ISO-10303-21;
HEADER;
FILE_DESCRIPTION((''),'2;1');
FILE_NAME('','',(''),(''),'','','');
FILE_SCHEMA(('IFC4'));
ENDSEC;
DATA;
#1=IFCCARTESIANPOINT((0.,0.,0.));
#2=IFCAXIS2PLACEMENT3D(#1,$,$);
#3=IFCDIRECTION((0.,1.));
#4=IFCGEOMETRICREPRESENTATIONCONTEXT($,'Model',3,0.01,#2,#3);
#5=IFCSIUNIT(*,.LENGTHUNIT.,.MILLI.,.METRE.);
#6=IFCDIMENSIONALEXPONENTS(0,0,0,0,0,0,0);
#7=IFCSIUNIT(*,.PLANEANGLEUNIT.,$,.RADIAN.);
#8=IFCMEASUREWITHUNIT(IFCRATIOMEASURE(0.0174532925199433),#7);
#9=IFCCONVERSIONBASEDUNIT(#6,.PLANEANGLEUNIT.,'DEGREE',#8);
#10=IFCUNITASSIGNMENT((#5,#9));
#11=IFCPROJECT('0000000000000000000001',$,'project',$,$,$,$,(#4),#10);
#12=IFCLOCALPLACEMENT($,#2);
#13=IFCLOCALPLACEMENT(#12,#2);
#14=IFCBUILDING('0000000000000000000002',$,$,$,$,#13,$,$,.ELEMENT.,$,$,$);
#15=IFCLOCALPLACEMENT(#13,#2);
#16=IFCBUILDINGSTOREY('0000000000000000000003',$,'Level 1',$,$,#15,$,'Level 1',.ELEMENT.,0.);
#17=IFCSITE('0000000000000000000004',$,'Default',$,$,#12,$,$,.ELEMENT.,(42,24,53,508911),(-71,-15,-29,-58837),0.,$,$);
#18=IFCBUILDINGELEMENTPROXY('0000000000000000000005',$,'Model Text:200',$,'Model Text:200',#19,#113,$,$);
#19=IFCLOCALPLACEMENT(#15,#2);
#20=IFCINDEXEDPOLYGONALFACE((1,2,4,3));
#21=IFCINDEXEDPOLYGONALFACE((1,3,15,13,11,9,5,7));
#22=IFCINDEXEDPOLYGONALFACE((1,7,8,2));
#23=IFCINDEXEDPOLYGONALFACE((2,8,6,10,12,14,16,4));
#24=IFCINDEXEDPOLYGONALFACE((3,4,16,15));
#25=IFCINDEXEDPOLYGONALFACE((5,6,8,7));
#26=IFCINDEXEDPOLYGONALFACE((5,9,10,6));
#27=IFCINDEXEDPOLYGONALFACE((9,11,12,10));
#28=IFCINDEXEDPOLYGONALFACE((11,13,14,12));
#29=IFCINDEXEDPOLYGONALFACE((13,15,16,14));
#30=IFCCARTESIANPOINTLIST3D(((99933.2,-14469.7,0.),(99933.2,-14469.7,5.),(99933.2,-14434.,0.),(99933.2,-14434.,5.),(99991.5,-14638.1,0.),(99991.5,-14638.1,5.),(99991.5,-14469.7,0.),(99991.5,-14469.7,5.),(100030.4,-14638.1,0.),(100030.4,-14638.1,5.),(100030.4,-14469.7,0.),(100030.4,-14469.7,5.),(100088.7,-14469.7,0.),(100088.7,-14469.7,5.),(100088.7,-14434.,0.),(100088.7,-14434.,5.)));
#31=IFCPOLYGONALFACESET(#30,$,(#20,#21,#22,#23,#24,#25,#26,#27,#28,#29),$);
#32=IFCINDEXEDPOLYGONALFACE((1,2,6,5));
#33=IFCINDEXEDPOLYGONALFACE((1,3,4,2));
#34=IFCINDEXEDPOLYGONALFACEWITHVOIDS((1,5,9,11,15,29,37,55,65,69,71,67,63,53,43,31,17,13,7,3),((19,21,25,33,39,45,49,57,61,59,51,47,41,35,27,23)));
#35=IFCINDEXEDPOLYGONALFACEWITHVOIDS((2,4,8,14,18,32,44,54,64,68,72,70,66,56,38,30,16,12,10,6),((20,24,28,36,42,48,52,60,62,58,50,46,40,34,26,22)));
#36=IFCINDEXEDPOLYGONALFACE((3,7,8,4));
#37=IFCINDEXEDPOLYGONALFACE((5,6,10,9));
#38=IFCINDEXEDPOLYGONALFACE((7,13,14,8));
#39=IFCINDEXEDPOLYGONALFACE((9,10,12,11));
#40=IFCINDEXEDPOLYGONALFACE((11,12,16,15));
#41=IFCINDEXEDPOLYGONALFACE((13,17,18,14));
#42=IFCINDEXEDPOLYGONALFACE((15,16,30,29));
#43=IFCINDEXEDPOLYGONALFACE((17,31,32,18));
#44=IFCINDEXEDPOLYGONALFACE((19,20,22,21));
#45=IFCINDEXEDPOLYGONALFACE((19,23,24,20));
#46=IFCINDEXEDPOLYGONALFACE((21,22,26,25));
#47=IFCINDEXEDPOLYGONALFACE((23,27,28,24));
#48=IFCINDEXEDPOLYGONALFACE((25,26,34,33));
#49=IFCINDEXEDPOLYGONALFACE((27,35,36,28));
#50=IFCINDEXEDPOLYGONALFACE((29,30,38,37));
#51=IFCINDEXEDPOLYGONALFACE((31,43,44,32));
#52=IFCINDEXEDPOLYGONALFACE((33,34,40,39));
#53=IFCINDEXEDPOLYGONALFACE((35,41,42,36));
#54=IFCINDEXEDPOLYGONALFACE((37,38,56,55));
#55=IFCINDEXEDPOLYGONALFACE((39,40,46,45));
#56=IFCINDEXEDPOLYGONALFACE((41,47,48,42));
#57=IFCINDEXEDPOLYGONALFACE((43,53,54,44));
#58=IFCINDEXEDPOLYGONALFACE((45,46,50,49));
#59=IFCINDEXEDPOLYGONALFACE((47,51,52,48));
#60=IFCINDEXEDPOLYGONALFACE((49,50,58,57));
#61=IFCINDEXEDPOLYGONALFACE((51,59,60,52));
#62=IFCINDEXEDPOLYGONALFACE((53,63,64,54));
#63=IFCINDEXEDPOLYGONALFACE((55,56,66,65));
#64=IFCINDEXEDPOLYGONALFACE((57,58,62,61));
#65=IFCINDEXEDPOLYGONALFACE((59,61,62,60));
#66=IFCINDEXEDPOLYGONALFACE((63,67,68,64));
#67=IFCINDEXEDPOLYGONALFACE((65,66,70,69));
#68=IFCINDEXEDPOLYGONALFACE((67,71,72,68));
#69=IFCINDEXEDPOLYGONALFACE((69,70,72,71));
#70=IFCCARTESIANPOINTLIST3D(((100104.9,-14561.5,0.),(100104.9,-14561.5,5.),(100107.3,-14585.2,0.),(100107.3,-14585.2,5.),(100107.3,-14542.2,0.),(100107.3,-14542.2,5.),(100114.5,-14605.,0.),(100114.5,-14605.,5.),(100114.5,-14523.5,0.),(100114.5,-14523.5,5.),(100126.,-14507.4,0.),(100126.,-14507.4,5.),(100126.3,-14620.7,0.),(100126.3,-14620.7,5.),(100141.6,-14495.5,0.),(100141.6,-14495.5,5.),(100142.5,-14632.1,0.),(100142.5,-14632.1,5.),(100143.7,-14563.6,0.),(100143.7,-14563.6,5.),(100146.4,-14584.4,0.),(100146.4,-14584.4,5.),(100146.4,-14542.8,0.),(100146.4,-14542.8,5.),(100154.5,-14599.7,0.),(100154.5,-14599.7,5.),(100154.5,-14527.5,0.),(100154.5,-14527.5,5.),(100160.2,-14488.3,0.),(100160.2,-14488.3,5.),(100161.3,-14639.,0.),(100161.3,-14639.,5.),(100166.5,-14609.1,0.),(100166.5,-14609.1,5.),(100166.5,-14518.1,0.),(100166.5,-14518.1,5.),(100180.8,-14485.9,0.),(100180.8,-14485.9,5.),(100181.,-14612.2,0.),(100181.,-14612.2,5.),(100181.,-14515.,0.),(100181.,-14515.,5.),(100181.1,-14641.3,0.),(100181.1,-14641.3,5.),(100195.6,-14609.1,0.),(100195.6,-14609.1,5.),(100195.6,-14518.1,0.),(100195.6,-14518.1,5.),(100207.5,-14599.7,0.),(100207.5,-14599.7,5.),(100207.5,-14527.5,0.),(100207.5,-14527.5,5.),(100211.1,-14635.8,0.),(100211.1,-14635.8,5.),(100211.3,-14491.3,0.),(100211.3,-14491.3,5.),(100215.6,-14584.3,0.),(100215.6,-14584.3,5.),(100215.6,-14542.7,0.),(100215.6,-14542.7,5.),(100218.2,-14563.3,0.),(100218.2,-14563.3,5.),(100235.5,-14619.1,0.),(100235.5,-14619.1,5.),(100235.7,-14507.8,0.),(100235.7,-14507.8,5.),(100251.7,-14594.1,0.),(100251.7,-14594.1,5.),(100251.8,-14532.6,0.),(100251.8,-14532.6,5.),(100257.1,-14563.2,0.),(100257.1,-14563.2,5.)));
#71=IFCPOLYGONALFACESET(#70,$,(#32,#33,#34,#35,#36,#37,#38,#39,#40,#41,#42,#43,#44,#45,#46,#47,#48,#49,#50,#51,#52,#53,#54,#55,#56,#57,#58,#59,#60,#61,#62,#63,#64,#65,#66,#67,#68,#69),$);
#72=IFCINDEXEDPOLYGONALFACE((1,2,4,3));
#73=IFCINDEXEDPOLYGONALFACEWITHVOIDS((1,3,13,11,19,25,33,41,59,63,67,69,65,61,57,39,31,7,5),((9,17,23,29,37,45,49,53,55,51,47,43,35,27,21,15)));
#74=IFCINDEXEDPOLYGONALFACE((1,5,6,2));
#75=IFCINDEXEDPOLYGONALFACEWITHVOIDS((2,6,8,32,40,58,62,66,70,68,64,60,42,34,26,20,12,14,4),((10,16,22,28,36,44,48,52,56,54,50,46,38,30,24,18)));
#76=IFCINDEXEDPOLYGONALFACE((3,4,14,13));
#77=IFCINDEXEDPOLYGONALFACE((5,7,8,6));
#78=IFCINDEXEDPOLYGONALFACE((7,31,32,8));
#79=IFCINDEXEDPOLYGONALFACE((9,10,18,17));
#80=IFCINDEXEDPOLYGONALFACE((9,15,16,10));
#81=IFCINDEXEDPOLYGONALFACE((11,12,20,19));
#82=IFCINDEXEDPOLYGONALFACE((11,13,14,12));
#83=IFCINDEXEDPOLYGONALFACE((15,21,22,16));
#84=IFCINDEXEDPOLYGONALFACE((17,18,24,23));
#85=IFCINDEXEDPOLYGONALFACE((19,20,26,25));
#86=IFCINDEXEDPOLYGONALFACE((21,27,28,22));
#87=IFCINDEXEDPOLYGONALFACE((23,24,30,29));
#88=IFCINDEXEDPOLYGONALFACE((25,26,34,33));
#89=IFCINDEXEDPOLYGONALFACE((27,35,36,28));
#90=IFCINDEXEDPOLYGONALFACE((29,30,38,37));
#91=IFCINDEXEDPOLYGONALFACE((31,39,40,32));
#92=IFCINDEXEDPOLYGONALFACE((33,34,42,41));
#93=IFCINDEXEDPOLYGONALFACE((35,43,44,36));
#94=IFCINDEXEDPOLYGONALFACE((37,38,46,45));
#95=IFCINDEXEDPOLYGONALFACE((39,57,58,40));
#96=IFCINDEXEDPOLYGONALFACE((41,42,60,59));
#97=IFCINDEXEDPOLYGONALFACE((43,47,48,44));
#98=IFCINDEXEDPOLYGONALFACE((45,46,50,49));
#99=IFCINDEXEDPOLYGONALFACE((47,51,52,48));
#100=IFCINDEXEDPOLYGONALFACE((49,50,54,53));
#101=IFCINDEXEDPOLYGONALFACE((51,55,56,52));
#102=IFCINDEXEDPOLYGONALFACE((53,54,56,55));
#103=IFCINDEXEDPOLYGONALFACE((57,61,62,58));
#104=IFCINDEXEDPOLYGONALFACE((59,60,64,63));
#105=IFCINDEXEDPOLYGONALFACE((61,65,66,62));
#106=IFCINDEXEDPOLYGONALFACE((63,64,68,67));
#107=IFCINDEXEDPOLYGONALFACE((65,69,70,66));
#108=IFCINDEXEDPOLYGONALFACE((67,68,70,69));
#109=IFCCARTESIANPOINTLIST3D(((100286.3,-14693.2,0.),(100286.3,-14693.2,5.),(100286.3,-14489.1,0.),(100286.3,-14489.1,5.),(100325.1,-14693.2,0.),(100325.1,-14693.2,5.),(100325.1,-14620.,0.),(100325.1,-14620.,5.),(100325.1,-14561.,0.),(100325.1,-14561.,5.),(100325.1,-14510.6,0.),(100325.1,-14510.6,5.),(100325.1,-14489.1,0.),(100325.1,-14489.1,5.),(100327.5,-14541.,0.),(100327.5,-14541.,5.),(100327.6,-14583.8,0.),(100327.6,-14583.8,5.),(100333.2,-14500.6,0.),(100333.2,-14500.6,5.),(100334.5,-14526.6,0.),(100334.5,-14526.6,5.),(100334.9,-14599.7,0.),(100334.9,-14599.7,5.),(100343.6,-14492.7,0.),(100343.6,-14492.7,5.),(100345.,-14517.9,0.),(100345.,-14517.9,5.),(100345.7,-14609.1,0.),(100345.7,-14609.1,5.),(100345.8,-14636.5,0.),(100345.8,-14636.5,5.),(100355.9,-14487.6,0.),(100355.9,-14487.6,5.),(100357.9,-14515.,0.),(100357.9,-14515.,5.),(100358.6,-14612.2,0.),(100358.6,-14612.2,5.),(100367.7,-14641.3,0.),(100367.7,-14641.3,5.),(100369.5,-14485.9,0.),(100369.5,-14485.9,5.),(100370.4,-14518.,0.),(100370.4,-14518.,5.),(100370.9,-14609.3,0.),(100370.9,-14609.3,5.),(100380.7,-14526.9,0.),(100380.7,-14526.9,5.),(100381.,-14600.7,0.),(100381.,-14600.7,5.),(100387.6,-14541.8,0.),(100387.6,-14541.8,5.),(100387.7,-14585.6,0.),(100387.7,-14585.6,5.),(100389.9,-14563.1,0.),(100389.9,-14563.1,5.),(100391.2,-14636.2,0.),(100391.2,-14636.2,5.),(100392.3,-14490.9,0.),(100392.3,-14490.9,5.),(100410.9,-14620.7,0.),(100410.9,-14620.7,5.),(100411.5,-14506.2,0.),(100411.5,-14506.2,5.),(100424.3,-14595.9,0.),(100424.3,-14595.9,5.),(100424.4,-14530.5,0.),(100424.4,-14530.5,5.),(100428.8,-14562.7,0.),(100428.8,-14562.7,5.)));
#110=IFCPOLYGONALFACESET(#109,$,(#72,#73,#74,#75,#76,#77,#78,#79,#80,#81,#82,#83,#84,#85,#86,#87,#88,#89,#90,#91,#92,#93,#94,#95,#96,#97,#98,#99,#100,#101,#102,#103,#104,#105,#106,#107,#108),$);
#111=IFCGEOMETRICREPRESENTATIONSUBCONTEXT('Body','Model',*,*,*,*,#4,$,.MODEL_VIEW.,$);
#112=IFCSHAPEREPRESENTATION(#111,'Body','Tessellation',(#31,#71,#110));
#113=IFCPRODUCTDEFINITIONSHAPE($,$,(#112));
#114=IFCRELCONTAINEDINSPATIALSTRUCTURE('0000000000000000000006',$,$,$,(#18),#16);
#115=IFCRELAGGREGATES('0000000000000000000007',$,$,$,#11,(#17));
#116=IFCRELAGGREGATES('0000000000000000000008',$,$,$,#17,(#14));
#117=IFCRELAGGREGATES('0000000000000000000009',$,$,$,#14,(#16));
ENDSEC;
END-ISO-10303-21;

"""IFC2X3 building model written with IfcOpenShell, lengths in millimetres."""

from ifc_helpers import new_model, entity, si_unit, converted_unit, direction, frame, origin, place, context, subcontext, project, spatial, polyline, outline, extrude, element, save


model = new_model("IFC2X3")

# Units and contexts
model_context = context("Model", 3, precision=0.01, world=origin(), true_north=direction((0.0, 1.0)))
body_context = subcontext(model_context, "Body", "Model", "MODEL_VIEW")
ifc_project = project(units=[si_unit("LENGTHUNIT", "METRE", prefix="MILLI"), converted_unit("PLANEANGLEUNIT", "DEGREE", entity("IfcRatioMeasure", 0.0174532925199433), si_unit("PLANEANGLEUNIT", "RADIAN"), dimensions=[0, 0, 0, 0, 0, 0, 0])], contexts=[model_context])

# Site, building, storey
site_placement = place(None, origin())
site = spatial("IfcSite", under=ifc_project, at=site_placement, Name="Default", CompositionType="ELEMENT", RefLatitude=(42, 24, 53, 508911), RefLongitude=(-71, -15, -29, -58837), RefElevation=0.0)
building_placement = place(site_placement, origin())
building = spatial("IfcBuilding", under=site, at=building_placement, CompositionType="ELEMENT")
storey_placement = place(building_placement, origin())
storey = spatial("IfcBuildingStorey", under=building, at=storey_placement, Name="Level 1", LongName="Level 1", CompositionType="ELEMENT", Elevation=0.0)

# Building element proxy
proxy_1_placement = place(storey_placement, origin())
element("IfcBuildingElementProxy", 1, at=proxy_1_placement, inside=storey, Name="Model Text:200", ObjectType="Model Text:200", context=body_context, shape_type="SweptSolid", body=[
    extrude(outline(polyline([(-19.4, -135.2), (19.4, -135.2), (19.4, 33.2), (77.7, 33.2), (77.7, 68.8), (-77.7, 68.8), (-77.7, 33.2), (-19.4, 33.2), (-19.4, -135.2)])), frame((100010.9, -14502.9, 0.0)), (0.0, 0.0, 1.0), 5.0),
    extrude(outline(polyline([(-8.8, -65.7), (15.1, -65.7), (35.5, -60.5), (52.3, -50.4), (65.3, -35.4), (74.1, -17.3), (78.4, 2.1), (75.9, 32.5), (61.8, 58.5), (38.4, 77.1), (8.3, 85.6), (-22.7, 83.3), (-49.0, 69.9), (-67.8, 47.3), (-76.3, 17.5), (-76.0, -3.3), (-70.7, -22.5), (-60.5, -39.2), (-45.5, -52.3), (-27.7, -61.4), (-8.8, -65.7)]), holes=[polyline([(-2.7, -27.2), (-23.1, -22.5), (-37.5, -12.9), (-45.7, 0.0), (-47.3, 14.8), (-42.7, 28.9), (-32.2, 39.9), (-16.3, 46.3), (4.5, 46.9), (25.1, 42.1), (39.6, 32.6), (47.7, 19.7), (49.4, 5.0), (44.8, -9.2), (34.2, -20.2), (18.2, -26.7), (-2.7, -27.2)])]), frame((100171.1, -14563.6, 0.0), z_axis=(0.0, 0.0, 1.0), x_axis=(0.100608, -0.994926, 0.0)), (0.0, 0.0, 1.0), 5.0),
    extrude(outline(polyline([(-73.1, -75.4), (130.9, -75.4), (130.9, -36.6), (57.8, -36.6), (74.3, -15.9), (79.1, 6.0), (73.9, 29.5), (58.4, 49.2), (33.6, 62.6), (0.5, 67.1), (-31.8, 62.8), (-56.1, 49.8), (-71.3, 30.7), (-76.4, 7.8), (-74.7, -5.8), (-69.6, -18.1), (-61.7, -28.5), (-51.7, -36.6), (-73.1, -36.6), (-73.1, -75.4)]), holes=[polyline([(-1.2, -36.6), (-21.2, -34.2), (-35.6, -27.2), (-44.3, -16.7), (-47.2, -3.8), (-44.3, 8.7), (-35.4, 19.0), (-20.4, 25.9), (0.8, 28.2), (23.3, 26.0), (38.5, 19.3), (47.1, 9.2), (49.9, -3.1), (46.8, -16.0), (37.4, -26.8), (21.5, -34.1), (-1.2, -36.6)])]), frame((100361.7, -14562.3, 0.0), z_axis=(0.0, 0.0, 1.0), x_axis=(0.0, -1.0, 0.0)), (0.0, 0.0, 1.0), 5.0),
])

save(model, "model.ifc")
